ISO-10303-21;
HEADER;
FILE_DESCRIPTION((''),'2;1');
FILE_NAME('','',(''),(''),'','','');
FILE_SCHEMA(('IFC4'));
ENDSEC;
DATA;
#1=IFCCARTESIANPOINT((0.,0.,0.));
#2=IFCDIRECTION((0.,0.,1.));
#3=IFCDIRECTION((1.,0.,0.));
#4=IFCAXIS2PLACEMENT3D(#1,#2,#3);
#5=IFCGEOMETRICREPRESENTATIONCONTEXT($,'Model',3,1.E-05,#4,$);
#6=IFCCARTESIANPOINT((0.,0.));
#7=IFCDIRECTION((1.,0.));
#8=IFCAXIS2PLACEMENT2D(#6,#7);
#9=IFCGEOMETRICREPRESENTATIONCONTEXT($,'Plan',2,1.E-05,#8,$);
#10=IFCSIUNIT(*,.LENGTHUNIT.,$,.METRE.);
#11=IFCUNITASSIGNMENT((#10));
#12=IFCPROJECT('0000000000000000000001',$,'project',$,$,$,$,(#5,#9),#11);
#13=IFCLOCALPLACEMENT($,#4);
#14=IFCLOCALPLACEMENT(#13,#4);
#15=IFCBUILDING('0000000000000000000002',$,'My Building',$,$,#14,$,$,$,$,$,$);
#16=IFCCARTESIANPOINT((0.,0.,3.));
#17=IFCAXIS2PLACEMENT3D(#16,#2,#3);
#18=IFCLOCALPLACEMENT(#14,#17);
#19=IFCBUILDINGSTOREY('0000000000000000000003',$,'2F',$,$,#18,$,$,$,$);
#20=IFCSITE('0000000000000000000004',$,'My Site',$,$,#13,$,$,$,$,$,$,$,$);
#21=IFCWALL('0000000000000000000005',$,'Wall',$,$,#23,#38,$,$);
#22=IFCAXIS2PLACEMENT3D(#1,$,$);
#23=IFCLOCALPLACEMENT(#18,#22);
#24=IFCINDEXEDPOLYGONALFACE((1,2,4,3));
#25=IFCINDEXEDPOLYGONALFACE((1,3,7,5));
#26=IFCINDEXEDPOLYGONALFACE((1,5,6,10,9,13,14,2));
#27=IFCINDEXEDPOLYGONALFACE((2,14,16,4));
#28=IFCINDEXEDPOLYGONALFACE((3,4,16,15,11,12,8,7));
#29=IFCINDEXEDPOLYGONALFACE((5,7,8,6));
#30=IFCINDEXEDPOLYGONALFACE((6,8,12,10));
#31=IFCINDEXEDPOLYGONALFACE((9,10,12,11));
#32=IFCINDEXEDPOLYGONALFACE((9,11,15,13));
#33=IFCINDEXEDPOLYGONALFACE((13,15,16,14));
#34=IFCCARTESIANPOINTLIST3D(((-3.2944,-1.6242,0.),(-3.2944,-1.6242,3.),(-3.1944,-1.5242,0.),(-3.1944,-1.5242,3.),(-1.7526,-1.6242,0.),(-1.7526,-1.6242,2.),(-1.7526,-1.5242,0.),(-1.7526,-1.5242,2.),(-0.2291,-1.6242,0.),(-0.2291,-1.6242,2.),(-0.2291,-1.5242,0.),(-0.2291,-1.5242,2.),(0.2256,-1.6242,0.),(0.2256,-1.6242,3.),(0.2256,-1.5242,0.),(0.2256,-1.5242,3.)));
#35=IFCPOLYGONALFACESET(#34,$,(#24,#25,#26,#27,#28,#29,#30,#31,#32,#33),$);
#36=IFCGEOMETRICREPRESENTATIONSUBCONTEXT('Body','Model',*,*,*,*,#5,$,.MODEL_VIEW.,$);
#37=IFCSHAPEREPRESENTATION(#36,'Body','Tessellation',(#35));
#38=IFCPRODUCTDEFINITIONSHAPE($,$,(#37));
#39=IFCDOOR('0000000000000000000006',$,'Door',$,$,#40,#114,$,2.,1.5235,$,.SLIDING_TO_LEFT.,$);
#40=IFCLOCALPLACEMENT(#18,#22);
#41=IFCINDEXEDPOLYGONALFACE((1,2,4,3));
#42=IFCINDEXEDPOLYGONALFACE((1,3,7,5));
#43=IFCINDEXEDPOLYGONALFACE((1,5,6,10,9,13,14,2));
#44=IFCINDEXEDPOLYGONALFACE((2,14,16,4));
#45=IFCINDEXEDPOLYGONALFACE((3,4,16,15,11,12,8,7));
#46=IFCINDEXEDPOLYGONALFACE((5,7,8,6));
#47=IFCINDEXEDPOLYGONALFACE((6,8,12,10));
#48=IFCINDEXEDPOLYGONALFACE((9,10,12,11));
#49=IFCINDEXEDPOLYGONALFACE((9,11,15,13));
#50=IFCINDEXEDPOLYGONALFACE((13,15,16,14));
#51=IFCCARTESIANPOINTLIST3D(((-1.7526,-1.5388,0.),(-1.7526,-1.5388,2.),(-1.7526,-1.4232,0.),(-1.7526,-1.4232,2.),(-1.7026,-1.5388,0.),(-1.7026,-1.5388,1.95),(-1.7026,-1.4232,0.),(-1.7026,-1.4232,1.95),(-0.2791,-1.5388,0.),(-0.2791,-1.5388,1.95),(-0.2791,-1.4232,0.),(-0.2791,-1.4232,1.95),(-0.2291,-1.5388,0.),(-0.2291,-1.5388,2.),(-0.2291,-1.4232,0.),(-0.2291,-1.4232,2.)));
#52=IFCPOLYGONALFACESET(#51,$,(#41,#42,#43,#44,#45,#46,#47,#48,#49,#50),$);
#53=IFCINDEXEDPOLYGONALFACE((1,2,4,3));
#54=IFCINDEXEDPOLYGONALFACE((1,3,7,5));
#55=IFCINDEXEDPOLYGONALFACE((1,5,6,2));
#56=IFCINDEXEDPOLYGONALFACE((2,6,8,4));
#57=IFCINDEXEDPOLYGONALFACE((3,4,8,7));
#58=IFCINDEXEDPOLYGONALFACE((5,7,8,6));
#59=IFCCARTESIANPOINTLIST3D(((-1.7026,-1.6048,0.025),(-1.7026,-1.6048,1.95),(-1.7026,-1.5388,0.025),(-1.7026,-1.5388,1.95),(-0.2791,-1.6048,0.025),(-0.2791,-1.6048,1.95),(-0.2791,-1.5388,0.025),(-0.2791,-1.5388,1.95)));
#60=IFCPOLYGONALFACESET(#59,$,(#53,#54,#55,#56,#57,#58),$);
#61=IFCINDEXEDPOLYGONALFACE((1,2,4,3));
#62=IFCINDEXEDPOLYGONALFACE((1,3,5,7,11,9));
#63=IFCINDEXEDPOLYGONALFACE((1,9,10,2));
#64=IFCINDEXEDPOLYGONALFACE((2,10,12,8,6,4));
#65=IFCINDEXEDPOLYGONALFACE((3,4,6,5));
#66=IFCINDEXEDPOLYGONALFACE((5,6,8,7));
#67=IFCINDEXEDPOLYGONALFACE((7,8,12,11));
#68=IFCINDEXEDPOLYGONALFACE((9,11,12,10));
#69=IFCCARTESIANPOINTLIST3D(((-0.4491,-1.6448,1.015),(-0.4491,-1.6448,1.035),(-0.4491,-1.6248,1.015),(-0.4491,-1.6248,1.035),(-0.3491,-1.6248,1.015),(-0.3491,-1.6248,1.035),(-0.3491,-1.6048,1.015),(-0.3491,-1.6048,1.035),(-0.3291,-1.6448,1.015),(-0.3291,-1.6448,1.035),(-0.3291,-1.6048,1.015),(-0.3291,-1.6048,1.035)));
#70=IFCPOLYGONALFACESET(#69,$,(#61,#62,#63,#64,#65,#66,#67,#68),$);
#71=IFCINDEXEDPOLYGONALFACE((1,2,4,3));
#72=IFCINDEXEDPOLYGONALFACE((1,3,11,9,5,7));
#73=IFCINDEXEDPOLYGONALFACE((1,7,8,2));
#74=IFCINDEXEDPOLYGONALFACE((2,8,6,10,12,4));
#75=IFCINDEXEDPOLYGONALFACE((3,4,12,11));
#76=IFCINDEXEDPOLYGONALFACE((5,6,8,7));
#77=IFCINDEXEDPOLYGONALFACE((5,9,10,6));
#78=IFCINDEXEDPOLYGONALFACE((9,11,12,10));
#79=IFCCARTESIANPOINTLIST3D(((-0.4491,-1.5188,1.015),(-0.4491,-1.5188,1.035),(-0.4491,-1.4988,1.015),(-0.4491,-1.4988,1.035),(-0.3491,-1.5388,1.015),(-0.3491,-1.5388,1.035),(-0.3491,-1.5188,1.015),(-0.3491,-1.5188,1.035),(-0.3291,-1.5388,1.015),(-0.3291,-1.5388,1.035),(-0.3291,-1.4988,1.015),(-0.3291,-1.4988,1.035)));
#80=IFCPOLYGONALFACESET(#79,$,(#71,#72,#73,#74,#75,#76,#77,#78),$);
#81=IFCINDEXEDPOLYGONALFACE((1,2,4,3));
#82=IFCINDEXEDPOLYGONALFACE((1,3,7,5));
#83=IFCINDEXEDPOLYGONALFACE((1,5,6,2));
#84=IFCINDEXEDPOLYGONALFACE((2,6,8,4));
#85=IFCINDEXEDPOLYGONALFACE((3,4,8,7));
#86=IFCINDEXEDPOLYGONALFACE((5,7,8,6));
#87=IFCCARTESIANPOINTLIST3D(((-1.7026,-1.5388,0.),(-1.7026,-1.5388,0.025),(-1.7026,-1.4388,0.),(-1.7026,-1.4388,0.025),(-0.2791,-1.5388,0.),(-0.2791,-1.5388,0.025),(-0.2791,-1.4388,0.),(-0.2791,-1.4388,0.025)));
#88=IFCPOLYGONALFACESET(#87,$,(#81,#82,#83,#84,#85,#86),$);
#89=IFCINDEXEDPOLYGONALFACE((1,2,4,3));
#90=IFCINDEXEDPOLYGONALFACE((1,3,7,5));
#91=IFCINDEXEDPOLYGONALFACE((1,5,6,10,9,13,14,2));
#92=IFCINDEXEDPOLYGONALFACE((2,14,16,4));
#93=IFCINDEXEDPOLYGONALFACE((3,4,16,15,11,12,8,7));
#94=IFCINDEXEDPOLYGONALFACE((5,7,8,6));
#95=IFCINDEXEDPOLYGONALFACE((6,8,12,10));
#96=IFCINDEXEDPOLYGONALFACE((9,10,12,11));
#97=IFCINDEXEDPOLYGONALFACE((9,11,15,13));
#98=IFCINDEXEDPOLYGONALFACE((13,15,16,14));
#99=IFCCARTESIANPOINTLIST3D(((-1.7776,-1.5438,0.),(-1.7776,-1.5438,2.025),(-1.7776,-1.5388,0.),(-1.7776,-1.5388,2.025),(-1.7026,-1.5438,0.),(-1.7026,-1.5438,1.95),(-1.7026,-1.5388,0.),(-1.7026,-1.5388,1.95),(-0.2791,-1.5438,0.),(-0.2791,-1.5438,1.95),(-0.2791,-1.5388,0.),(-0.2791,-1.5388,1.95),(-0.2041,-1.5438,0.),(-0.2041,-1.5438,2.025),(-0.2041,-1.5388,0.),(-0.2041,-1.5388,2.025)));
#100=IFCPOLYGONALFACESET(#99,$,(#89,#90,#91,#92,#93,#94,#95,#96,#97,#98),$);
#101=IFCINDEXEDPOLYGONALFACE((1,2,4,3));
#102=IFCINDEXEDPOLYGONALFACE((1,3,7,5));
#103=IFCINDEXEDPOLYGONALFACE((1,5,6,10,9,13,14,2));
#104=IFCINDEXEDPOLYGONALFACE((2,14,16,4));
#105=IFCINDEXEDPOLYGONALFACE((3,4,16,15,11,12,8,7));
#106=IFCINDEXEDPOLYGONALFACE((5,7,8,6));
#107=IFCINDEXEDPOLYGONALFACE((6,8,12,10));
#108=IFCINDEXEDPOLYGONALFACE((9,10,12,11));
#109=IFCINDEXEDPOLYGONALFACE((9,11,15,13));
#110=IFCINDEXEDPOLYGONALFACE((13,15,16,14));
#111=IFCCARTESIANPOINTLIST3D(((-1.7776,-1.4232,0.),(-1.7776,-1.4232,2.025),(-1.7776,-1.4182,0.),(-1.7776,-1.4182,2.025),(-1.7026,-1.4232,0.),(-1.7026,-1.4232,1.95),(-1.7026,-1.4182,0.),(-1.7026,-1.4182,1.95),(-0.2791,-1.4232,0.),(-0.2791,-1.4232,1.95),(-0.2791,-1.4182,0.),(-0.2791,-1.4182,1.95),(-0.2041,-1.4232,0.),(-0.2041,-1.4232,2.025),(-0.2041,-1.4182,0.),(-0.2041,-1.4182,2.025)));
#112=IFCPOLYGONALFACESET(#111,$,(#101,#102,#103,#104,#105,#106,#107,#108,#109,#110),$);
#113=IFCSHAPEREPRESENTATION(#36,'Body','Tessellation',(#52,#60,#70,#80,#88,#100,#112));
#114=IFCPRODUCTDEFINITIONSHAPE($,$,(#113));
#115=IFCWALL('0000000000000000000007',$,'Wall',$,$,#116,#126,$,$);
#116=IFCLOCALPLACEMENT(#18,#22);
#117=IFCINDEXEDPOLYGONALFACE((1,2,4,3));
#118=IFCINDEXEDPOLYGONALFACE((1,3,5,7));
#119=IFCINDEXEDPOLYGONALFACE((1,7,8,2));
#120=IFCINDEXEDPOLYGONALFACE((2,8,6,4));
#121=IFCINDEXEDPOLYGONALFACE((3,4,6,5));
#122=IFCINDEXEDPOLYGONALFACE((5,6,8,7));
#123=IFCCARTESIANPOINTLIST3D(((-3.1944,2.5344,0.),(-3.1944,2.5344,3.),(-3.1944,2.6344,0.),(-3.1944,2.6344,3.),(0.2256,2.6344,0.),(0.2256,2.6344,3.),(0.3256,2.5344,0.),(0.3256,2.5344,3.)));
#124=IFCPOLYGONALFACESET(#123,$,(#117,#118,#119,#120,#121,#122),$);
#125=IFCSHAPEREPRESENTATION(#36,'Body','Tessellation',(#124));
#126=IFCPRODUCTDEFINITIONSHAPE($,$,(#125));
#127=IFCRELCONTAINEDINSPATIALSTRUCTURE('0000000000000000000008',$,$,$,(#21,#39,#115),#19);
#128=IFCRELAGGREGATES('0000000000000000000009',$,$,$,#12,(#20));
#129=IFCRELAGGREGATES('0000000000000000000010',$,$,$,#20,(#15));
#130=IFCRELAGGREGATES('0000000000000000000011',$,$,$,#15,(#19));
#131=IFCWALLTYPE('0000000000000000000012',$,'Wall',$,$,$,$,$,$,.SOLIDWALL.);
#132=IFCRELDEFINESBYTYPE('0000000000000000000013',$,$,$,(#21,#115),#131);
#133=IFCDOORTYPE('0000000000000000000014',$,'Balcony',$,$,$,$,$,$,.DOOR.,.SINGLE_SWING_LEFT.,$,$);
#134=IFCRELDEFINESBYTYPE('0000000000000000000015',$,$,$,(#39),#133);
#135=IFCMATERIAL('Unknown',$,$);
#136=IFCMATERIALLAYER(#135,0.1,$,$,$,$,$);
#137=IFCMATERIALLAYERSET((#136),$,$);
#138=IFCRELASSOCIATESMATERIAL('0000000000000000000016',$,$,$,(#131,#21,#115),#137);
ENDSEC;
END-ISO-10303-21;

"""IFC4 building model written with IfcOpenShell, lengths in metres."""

from ifc_helpers import new_model, entity, si_unit, frame, origin_with_axes, origin_2d_with_axis, place, context, subcontext, project, spatial, line, indexed_curve, outline, extrude, shape, source, transform, mapped, material, layer, layer_set, layer_usage, type_object, type_shapes, element, fill, save


model = new_model("IFC4")

# Units and contexts
model_context = context("Model", 3, precision=1e-05, world=origin_with_axes())
plan_context = context("Plan", 2, precision=1e-05, world=origin_2d_with_axis())
body_context_1 = subcontext(model_context, "Body", "Model", "MODEL_VIEW")
body_context_2 = subcontext(plan_context, "Body", "Plan", "PLAN_VIEW")
ifc_project = project(units=[si_unit("LENGTHUNIT", "METRE")], contexts=[model_context, plan_context])

# Site, building, storey
site_placement = place(None, origin_with_axes())
site = spatial("IfcSite", under=ifc_project, at=site_placement, Name="My Site")
building_placement = place(site_placement, origin_with_axes())
building = spatial("IfcBuilding", under=site, at=building_placement, Name="My Building")
storey_placement = place(building_placement, frame((0.0, 0.0, 3.0), z_axis=(0.0, 0.0, 1.0), x_axis=(1.0, 0.0, 0.0)))
storey = spatial("IfcBuildingStorey", under=building, at=storey_placement, Name="2F")

# Shared definitions
ifc_material = material(Name="Unknown")

# Shared definitions
ifc_layer = layer(ifc_material, 0.1)
ifc_layer_set = layer_set([ifc_layer])
wall_type = type_object("IfcWallType", Name="Wall", PredefinedType="SOLIDWALL", material=ifc_layer_set)

# Wall, opening, door
ifc_layer_usage_1 = layer_usage(ifc_layer_set, "AXIS2", "POSITIVE", 0.0)
wall_1_placement = place(storey_placement, frame((-3.2944, -1.6242, 0.0), z_axis=(0.0, 0.0, 1.0), x_axis=(1.0, 0.0, 0.0)))
wall_1 = element("IfcWall", 1, at=wall_1_placement, inside=storey, type_object=wall_type, material=ifc_layer_usage_1, Name="Wall", context=body_context_1, shape_type="SweptSolid", body=[
    extrude(outline(indexed_curve([(0.0, 0.0), (0.1, 0.1), (3.52, 0.1), (3.52, 0.0)], segments=[line(1, 2, 3, 4, 1)])), origin_with_axes(), (0.0, 0.0, 1.0), 3.0),
])
shared_shape_1 = source(origin_with_axes(), body_context_1, "Body", "SweptSolid", [
    extrude(outline(indexed_curve([(0.0, 0.0), (1.5235, 0.0), (1.5235, 2.0), (0.0, 2.0)], segments=[line(1, 2, 3, 4, 1)])), frame((0.0, -0.6, 0.0), z_axis=(0.0, -1.0, 0.0), x_axis=(1.0, 0.0, 0.0)), (0.0, 0.0, -1.0), 1.2),
])
opening_1_placement = place(wall_1_placement, frame((1.5418, 0.0855, 0.0), z_axis=(0.0, 0.0, 1.0), x_axis=(1.0, -0.000001, 0.0)))
opening_1 = element("IfcOpeningElement", 2, at=opening_1_placement, cuts=wall_1, PredefinedType="OPENING", context=body_context_1, shape_type="MappedRepresentation", body=[
    mapped(shared_shape_1, transform((0.0, 0.0, 0.0), x_axis=(1.0, 0.0, 0.0), y_axis=(0.0, 1.0, 0.0), z_axis=(0.0, 0.0, 1.0), scale=1.0)),
])
door_type_1 = type_object("IfcDoorType", Name="Balcony", OperationType="SINGLE_SWING_LEFT", PredefinedType="DOOR")
shared_shape_2 = source(origin_with_axes(), body_context_1, "Body", "SweptSolid", [
    extrude(outline(indexed_curve([(0.0, 0.0), (0.0, 2.0), (1.5235, 2.0), (1.5235, 0.0), (1.4735, 0.0), (1.4735, 1.95), (0.05, 1.95), (0.05, 0.0)], segments=[line(1, 2, 3, 4, 5, 6, 7, 8, 1)])), frame((0.0, 0.0, 0.0), z_axis=(0.0, -1.0, 0.0), x_axis=(1.0, 0.0, 0.0)), (0.0, 0.0, -1.0), 0.1156),
    extrude(outline(indexed_curve([(0.0, 0.0), (1.4235, 0.0), (1.4235, 0.0661), (0.0, 0.0661)], segments=[line(1, 2, 3, 4, 1)])), frame((0.05, -0.0661, 0.025), z_axis=(0.0, 0.0, 1.0), x_axis=(1.0, 0.0, 0.0)), (0.0, 0.0, 1.0), 1.925),
    extrude(outline(indexed_curve([(0.0, 0.0), (0.0, -0.04), (-0.12, -0.04), (-0.12, -0.02), (-0.02, -0.02), (-0.02, 0.0)], segments=[line(1, 2, 3, 4, 5, 6, 1)])), frame((1.4235, -0.0661, 1.015), z_axis=(0.0, 0.0, 1.0), x_axis=(1.0, 0.0, 0.0)), (0.0, 0.0, 1.0), 0.02),
    extrude(outline(indexed_curve([(0.0, 0.0), (0.0, 0.04), (-0.12, 0.04), (-0.12, 0.02), (-0.02, 0.02), (-0.02, 0.0)], segments=[line(1, 2, 3, 4, 5, 6, 1)])), frame((1.4235, 0.0, 1.015), z_axis=(0.0, 0.0, 1.0), x_axis=(1.0, 0.0, 0.0)), (0.0, 0.0, 1.0), 0.02),
    extrude(outline(indexed_curve([(0.0, 0.0), (1.4235, 0.0), (1.4235, 0.1), (0.0, 0.1)], segments=[line(1, 2, 3, 4, 1)])), frame((0.05, 0.0, 0.0), z_axis=(0.0, 0.0, 1.0), x_axis=(1.0, 0.0, 0.0)), (0.0, 0.0, 1.0), 0.025),
    extrude(outline(indexed_curve([(0.0, 0.0), (0.0, 2.025), (1.5735, 2.025), (1.5735, 0.0), (1.4985, 0.0), (1.4985, 1.95), (0.075, 1.95), (0.075, 0.0)], segments=[line(1, 2, 3, 4, 5, 6, 7, 8, 1)])), frame((-0.025, -0.005, 0.0), z_axis=(0.0, -1.0, 0.0), x_axis=(1.0, 0.0, 0.0)), (0.0, 0.0, -1.0), 0.005),
    extrude(outline(indexed_curve([(0.0, 0.0), (0.0, 2.025), (1.5735, 2.025), (1.5735, 0.0), (1.4985, 0.0), (1.4985, 1.95), (0.075, 1.95), (0.075, 0.0)], segments=[line(1, 2, 3, 4, 5, 6, 7, 8, 1)])), frame((-0.025, 0.1156, 0.0), z_axis=(0.0, -1.0, 0.0), x_axis=(1.0, 0.0, 0.0)), (0.0, 0.0, -1.0), 0.005),
])
shared_shape_3 = source(origin_with_axes(), body_context_2, "Body", "Curve2D", [
    entity("IfcIndexedPolyCurve", entity("IfcCartesianPointList2D", [[0.0, 0.0], [0.05, 0.0], [0.05, 0.1156], [0.0, 0.1156]]), [entity("IfcLineIndex", [1, 2, 3, 4, 1])]),
    entity("IfcIndexedPolyCurve", entity("IfcCartesianPointList2D", [[1.5235, 0.0], [1.4735, 0.0], [1.4735, 0.1156], [1.5235, 0.1156]]), [entity("IfcLineIndex", [1, 2, 3, 4, 1])]),
    entity("IfcIndexedPolyCurve", entity("IfcCartesianPointList2D", [[-0.6617, -0.0661], [0.7617, -0.0661], [0.7617, 0.0], [-0.6617, 0.0]]), [entity("IfcLineIndex", [1, 2, 3, 4, 1])]),
])
type_shapes(door_type_1, [shared_shape_2, shared_shape_3])
door_1_placement = place(opening_1_placement, frame((0.0, 0.0, 0.0), z_axis=(0.0, 0.0, 1.0), x_axis=(1.0, 0.0, 0.0)))
door_1 = element("IfcDoor", 3, at=door_1_placement, inside=storey, type_object=door_type_1, Name="Door", OperationType="SLIDING_TO_LEFT", OverallHeight=2.0, OverallWidth=1.5235, shapes=[
    shape(body_context_1, "Body", "MappedRepresentation", [mapped(shared_shape_2, transform((0.0, 0.0, 0.0), x_axis=(1.0, 0.0, 0.0), y_axis=(0.0, 1.0, 0.0), z_axis=(0.0, 0.0, 1.0), scale=1.0))]),
    shape(body_context_2, "Body", "MappedRepresentation", [mapped(shared_shape_3, transform((0.0, 0.0, 0.0), x_axis=(1.0, 0.0, 0.0), y_axis=(0.0, 1.0, 0.0), z_axis=(0.0, 0.0, 1.0), scale=1.0))]),
])
fill(opening_1, door_1)

# Wall
ifc_layer_usage_2 = layer_usage(ifc_layer_set, "AXIS2", "POSITIVE", 0.0)
wall_2_placement = place(storey_placement, frame((-3.1944, 2.5344, 0.0), z_axis=(0.0, 0.0, 1.0), x_axis=(1.0, 0.0, 0.0)))
element("IfcWall", 4, at=wall_2_placement, inside=storey, type_object=wall_type, material=ifc_layer_usage_2, Name="Wall", context=body_context_1, shape_type="SweptSolid", body=[
    extrude(outline(indexed_curve([(0.0, 0.0), (0.0, 0.1), (3.42, 0.1), (3.52, 0.0)], segments=[line(1, 2, 3, 4, 1)])), origin_with_axes(), (0.0, 0.0, 1.0), 3.0),
])

save(model, "model.ifc")
